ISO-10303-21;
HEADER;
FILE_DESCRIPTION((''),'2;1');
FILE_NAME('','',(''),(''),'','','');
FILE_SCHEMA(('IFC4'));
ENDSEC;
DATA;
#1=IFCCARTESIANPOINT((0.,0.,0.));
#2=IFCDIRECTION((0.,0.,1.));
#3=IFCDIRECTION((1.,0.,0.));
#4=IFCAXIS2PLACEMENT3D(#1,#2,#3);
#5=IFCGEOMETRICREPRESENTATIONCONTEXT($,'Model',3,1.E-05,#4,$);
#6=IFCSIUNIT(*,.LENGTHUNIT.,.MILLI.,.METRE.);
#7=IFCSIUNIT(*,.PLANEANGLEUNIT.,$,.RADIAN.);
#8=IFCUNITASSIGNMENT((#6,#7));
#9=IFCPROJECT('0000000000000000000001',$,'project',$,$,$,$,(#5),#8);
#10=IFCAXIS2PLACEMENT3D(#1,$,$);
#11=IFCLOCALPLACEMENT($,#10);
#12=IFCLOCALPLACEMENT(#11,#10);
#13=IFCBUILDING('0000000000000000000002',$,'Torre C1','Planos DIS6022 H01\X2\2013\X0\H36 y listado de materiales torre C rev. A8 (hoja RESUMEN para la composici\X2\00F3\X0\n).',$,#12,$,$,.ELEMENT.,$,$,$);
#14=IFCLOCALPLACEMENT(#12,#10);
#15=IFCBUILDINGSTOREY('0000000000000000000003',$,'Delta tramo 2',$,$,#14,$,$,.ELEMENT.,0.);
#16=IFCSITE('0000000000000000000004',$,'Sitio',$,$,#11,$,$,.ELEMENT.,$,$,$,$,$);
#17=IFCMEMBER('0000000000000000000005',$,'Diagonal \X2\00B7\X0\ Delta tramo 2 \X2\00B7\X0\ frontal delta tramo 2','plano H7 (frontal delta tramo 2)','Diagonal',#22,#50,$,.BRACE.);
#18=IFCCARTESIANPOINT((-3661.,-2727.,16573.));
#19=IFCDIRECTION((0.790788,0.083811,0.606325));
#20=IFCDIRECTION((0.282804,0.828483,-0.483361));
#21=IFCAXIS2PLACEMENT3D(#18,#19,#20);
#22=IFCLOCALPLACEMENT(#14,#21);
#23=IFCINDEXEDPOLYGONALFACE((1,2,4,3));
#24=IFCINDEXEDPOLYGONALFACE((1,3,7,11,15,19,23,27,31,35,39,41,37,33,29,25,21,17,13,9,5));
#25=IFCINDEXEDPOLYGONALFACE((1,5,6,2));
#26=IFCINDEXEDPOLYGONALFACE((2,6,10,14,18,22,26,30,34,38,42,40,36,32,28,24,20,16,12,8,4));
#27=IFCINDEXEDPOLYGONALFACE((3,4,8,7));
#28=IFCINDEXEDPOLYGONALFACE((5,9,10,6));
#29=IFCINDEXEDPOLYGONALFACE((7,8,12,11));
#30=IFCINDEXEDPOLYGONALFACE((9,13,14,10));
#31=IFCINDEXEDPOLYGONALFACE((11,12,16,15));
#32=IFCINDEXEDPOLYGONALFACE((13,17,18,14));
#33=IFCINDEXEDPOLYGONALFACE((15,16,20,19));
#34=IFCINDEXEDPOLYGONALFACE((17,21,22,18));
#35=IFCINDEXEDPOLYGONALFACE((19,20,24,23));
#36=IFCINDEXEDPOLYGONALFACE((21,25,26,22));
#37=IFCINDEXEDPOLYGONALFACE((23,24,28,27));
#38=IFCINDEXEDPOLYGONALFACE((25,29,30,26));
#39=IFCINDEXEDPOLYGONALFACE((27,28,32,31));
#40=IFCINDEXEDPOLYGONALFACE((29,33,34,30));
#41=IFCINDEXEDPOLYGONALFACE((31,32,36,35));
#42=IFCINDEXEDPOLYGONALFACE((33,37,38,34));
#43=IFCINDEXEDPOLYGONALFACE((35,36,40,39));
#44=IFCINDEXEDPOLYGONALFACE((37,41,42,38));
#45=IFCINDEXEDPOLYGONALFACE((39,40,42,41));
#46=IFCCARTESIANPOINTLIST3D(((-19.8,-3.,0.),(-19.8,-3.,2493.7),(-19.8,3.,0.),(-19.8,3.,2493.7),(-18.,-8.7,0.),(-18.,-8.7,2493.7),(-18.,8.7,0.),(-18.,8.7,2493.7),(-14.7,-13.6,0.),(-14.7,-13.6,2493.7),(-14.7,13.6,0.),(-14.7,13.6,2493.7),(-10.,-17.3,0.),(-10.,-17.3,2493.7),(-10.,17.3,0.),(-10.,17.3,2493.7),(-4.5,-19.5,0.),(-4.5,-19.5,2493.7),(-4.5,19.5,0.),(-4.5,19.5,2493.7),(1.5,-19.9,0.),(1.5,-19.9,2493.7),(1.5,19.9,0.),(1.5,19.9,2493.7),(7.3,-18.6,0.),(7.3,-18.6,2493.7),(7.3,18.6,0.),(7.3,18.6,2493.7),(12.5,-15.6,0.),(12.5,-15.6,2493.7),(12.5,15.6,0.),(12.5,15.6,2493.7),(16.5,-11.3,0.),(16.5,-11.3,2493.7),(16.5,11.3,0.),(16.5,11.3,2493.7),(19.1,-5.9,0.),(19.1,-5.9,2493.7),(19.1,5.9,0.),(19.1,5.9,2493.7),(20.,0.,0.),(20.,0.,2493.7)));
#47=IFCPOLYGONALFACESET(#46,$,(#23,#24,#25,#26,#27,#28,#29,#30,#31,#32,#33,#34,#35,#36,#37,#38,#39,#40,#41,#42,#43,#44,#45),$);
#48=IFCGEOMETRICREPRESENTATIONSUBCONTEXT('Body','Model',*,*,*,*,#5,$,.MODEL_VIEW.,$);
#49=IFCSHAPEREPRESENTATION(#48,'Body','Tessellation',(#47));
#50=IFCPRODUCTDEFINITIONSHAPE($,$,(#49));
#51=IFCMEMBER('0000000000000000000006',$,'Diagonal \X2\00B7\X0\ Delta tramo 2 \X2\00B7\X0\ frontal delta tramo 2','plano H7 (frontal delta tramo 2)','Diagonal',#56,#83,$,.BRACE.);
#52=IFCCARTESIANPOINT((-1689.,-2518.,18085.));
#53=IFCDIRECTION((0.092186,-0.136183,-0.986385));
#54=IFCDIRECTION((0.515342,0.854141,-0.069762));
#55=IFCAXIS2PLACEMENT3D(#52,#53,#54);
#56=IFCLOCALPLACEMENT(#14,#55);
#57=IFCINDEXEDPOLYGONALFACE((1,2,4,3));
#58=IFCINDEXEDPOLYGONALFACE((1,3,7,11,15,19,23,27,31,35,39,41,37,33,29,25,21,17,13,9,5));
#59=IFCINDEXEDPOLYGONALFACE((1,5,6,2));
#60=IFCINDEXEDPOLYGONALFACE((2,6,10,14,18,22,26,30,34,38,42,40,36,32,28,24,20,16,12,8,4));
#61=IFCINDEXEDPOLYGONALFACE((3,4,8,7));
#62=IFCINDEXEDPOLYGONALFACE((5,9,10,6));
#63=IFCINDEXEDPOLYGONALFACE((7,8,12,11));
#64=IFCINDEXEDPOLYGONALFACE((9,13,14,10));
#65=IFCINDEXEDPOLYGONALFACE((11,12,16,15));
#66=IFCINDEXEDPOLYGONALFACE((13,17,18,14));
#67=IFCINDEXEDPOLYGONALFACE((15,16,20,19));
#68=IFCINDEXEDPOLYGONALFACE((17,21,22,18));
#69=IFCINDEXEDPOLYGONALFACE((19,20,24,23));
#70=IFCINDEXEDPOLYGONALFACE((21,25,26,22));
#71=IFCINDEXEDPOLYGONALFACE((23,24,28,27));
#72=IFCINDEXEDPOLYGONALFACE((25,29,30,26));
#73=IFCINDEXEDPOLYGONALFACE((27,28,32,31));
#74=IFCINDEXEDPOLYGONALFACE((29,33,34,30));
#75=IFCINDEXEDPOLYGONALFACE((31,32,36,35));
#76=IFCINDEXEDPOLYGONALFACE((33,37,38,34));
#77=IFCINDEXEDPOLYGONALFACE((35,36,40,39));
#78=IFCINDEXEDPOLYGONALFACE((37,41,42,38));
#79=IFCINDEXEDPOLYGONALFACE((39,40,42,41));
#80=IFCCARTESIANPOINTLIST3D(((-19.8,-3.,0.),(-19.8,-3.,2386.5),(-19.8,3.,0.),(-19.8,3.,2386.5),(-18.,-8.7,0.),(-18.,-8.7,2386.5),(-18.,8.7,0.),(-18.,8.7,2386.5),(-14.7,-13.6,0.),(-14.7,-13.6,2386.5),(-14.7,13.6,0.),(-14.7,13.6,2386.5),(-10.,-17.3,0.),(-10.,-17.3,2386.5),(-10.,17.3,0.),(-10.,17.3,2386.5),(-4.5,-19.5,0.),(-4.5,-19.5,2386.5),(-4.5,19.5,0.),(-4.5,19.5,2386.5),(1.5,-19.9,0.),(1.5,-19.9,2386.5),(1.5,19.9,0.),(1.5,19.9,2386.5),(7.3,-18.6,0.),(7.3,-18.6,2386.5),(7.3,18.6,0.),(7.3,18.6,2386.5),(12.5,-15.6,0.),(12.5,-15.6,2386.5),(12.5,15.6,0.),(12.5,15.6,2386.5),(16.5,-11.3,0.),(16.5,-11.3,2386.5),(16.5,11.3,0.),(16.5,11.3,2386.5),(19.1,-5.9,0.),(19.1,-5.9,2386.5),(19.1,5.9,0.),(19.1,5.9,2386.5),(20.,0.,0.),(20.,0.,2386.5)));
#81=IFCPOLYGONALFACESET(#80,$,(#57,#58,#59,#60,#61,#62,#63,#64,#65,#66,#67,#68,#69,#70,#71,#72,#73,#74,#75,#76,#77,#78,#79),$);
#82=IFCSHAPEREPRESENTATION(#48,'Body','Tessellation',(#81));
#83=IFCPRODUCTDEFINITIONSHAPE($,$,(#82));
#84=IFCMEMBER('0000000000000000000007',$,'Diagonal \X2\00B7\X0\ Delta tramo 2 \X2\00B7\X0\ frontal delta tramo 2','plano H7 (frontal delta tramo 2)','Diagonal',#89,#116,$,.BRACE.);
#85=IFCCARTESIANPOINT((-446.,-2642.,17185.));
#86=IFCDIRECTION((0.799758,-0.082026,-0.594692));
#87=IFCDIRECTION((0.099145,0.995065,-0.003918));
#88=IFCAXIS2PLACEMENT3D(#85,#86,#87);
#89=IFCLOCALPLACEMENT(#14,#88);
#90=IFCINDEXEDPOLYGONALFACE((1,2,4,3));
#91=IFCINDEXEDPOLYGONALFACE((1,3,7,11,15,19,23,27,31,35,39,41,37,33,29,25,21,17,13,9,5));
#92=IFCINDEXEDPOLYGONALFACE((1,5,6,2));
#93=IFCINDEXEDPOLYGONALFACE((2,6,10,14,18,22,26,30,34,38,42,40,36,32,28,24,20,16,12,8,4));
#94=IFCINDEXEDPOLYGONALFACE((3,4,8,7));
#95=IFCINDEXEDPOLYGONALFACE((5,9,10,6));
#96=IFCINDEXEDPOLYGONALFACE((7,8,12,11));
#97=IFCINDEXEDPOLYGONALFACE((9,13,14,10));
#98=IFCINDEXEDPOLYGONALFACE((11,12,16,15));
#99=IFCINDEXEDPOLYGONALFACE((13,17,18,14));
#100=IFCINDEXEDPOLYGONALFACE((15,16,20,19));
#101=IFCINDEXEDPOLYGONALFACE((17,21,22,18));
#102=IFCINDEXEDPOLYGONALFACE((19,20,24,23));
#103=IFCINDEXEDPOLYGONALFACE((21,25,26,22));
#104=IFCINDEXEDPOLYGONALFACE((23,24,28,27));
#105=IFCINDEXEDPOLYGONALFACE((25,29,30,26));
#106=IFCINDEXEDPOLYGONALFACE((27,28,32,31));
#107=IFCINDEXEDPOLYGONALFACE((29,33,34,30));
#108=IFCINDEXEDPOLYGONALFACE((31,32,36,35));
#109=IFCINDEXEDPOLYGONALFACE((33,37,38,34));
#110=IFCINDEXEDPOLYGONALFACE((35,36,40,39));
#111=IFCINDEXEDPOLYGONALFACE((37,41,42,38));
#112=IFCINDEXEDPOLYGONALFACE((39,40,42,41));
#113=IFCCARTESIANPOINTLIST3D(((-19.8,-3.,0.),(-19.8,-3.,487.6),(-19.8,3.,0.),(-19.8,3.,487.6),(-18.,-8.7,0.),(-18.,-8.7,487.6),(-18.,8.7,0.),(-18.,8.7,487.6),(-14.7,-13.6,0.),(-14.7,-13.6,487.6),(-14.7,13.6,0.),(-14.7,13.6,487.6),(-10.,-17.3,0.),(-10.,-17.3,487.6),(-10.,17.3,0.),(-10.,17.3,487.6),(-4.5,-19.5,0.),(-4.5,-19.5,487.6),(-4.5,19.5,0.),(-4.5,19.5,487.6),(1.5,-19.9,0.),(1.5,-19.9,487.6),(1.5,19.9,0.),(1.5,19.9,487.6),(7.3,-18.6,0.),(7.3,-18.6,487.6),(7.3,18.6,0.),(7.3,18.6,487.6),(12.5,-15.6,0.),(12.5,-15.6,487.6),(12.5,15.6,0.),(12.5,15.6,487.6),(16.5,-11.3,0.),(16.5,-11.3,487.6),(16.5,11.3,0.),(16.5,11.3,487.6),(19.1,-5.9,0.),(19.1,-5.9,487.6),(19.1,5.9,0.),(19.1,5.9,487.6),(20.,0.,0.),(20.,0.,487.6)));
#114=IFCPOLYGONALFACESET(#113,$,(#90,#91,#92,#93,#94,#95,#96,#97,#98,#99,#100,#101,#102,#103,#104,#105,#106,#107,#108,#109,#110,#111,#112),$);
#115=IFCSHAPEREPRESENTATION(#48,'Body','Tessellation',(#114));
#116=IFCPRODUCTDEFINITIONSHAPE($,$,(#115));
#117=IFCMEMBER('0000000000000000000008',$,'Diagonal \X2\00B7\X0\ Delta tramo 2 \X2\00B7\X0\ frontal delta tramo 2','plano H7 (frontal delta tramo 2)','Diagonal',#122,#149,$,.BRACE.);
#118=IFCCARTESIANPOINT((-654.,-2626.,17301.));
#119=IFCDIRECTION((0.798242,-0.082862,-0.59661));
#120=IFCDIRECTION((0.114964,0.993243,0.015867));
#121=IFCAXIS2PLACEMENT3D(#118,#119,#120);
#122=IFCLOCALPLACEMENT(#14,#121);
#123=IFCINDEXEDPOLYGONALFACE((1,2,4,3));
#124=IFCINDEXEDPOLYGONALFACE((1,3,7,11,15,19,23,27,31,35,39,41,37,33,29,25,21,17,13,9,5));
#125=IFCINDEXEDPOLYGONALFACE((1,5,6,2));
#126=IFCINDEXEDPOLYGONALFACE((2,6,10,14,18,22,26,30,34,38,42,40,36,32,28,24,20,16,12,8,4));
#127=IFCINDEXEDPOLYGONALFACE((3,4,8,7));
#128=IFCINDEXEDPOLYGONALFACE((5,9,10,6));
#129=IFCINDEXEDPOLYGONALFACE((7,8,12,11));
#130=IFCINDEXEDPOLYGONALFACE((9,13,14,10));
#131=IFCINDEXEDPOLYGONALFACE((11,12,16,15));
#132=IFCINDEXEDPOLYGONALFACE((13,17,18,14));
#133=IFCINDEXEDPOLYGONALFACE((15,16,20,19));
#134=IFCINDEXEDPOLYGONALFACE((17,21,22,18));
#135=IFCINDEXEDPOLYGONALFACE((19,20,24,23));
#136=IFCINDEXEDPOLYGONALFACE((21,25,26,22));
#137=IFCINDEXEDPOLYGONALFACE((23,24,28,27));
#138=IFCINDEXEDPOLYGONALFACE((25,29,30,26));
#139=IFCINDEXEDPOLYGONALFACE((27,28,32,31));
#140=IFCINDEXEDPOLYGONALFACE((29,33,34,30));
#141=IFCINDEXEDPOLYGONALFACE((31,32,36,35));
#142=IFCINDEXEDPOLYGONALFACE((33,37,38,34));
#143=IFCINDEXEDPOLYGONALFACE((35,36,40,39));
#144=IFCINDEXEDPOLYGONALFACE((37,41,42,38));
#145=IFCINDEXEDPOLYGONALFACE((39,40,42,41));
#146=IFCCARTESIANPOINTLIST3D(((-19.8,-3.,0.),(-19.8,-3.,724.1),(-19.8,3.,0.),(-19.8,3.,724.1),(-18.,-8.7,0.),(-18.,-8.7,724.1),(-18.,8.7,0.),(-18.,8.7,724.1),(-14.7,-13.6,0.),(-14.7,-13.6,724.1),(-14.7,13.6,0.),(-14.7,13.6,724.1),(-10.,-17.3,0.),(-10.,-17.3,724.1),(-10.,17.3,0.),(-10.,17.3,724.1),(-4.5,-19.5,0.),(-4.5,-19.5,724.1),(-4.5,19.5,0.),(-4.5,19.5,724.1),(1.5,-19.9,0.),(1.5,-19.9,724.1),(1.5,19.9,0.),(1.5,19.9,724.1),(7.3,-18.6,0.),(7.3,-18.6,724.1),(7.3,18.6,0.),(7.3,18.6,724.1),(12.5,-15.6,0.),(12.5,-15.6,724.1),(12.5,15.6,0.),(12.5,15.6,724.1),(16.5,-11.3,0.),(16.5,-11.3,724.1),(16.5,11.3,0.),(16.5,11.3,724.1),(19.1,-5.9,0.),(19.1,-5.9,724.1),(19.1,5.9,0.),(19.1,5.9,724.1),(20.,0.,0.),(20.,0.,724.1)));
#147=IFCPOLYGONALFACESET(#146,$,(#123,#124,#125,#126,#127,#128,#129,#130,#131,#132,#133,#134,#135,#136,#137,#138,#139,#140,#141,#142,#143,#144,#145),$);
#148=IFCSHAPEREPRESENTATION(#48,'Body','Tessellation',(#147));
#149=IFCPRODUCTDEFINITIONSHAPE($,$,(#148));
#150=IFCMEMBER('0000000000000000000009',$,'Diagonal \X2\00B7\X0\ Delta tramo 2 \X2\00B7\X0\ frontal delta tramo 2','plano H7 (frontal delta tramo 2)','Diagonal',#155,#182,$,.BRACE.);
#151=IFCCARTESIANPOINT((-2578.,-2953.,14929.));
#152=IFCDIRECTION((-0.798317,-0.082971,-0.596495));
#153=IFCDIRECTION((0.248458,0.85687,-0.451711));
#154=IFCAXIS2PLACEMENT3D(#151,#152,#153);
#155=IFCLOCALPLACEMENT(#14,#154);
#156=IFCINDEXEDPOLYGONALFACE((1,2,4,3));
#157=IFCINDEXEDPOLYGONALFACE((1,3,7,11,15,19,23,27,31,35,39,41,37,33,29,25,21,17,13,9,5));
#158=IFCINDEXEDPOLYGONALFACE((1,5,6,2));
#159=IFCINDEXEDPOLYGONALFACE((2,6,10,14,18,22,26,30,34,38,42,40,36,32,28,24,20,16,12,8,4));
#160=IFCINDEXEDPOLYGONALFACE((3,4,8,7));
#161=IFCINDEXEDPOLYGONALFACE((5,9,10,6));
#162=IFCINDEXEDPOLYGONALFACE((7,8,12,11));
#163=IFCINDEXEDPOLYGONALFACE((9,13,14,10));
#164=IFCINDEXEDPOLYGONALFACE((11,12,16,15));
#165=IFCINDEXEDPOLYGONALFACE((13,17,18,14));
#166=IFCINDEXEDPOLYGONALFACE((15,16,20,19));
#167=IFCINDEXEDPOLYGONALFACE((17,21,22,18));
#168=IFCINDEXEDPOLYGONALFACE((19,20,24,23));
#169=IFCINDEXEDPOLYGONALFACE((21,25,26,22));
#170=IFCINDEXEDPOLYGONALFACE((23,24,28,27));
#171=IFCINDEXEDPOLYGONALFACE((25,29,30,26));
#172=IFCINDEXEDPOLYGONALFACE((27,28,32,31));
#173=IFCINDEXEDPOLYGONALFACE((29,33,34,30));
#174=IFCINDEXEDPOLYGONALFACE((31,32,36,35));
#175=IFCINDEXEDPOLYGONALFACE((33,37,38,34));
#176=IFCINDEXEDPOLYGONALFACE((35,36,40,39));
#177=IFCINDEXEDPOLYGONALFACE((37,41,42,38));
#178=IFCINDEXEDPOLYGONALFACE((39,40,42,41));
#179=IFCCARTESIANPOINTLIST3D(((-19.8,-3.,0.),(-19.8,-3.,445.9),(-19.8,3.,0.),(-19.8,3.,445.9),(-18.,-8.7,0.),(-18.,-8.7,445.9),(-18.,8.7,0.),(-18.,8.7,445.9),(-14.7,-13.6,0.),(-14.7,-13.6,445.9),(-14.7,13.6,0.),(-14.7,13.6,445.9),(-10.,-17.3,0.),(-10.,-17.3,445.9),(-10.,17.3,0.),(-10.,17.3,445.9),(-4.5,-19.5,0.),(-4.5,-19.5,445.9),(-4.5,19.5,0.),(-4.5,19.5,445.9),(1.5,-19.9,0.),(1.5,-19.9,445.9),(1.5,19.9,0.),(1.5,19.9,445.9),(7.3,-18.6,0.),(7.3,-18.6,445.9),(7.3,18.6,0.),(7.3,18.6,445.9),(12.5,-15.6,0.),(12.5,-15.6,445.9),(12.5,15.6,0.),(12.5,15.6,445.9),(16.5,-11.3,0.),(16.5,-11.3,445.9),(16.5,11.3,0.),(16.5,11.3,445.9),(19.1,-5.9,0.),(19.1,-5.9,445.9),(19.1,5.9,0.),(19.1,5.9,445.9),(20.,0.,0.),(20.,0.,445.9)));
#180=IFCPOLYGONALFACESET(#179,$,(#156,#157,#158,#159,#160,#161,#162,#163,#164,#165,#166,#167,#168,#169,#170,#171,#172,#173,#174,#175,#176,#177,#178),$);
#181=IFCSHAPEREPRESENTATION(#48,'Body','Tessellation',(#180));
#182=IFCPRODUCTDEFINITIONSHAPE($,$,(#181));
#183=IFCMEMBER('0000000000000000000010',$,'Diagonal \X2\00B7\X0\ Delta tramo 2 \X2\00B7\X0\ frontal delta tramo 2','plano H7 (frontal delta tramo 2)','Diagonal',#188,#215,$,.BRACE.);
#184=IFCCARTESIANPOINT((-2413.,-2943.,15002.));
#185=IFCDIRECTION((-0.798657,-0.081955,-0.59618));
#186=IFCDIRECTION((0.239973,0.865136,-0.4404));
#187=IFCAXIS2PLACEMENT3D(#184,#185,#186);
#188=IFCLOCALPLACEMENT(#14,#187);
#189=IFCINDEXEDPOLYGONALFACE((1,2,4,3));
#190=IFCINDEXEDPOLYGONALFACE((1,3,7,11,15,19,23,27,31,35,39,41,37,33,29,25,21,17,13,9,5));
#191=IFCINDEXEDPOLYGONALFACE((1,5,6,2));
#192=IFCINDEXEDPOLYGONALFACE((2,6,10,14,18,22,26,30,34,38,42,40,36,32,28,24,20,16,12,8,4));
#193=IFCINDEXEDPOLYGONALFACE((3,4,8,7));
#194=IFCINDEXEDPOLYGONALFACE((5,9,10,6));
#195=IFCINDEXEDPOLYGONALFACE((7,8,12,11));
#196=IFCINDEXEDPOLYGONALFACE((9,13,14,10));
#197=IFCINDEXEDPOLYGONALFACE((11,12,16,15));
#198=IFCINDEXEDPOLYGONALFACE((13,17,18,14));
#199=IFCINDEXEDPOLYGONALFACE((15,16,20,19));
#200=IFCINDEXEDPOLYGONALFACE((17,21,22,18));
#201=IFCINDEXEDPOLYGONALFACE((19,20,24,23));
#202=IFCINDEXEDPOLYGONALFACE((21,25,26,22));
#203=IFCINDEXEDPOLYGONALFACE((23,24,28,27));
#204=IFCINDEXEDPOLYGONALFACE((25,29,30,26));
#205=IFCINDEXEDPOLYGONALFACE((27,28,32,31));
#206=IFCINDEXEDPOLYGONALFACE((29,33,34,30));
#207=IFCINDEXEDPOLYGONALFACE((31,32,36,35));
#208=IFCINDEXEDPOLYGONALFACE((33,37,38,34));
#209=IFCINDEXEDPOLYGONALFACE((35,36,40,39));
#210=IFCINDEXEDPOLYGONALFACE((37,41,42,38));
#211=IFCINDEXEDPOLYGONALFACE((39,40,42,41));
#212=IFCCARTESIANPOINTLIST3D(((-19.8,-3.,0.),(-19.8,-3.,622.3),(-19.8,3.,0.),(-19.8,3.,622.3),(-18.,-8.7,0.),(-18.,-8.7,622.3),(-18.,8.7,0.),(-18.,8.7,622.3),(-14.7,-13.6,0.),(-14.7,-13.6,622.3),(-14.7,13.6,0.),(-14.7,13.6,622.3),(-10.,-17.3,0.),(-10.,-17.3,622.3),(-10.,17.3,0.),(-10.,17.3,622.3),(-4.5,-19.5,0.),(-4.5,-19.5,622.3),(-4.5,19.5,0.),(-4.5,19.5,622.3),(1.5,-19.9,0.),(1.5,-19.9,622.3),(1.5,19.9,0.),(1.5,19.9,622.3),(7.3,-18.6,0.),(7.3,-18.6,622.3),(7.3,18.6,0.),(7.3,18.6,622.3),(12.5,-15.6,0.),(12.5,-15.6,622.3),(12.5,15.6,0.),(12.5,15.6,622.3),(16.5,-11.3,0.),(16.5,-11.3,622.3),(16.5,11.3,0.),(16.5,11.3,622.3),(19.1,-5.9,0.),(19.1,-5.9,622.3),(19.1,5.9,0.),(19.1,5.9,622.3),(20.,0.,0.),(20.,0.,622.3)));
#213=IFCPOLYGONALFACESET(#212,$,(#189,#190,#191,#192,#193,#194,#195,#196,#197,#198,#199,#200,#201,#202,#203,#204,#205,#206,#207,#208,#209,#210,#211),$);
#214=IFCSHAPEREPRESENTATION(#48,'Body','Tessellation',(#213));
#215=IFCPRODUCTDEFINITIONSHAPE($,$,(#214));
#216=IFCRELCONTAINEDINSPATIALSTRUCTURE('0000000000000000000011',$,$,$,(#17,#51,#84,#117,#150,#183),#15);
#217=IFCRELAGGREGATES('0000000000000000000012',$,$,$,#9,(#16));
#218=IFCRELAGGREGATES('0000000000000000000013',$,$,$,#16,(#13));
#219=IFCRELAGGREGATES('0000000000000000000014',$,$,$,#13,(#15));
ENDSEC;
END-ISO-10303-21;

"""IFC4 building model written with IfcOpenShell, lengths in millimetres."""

from ifc_helpers import new_model, si_unit, frame, origin, origin_with_axes, place, context, subcontext, project, spatial, circle, extrude, element, save


model = new_model("IFC4")

# Units and contexts
model_context = context("Model", 3, precision=1e-05, world=origin_with_axes())
body_context = subcontext(model_context, "Body", "Model", "MODEL_VIEW")
ifc_project = project(units=[si_unit("LENGTHUNIT", "METRE", prefix="MILLI"), si_unit("PLANEANGLEUNIT", "RADIAN")], contexts=[model_context])

# Site, building, storey
site_placement = place(None, origin())
site = spatial("IfcSite", under=ifc_project, at=site_placement, Name="Sitio", CompositionType="ELEMENT")
building_placement = place(site_placement, origin())
building = spatial("IfcBuilding", under=site, at=building_placement, Name="Torre C1", Description="Planos DIS6022 H01–H36 y listado de materiales torre C rev. A8 (hoja RESUMEN para la composición).", CompositionType="ELEMENT")
storey_placement = place(building_placement, origin())
storey = spatial("IfcBuildingStorey", under=building, at=storey_placement, Name="Delta tramo 2", CompositionType="ELEMENT", Elevation=0.0)

# Members
member_1_placement = place(storey_placement, frame((-3661.0, -2727.0, 16573.0), z_axis=(0.790788, 0.083811, 0.606325), x_axis=(0.282804, 0.828483, -0.483361)))
element("IfcMember", 1, at=member_1_placement, inside=storey, Name="Diagonal · Delta tramo 2 · frontal delta tramo 2", Description="plano H7 (frontal delta tramo 2)", ObjectType="Diagonal", PredefinedType="BRACE", context=body_context, shape_type="SweptSolid", body=[
    extrude(circle(Radius=20.0), None, (0.0, 0.0, 1.0), 2493.7),
])
member_2_placement = place(storey_placement, frame((-1689.0, -2518.0, 18085.0), z_axis=(0.092186, -0.136183, -0.986385), x_axis=(0.515342, 0.854141, -0.069762)))
element("IfcMember", 2, at=member_2_placement, inside=storey, Name="Diagonal · Delta tramo 2 · frontal delta tramo 2", Description="plano H7 (frontal delta tramo 2)", ObjectType="Diagonal", PredefinedType="BRACE", context=body_context, shape_type="SweptSolid", body=[
    extrude(circle(Radius=20.0), None, (0.0, 0.0, 1.0), 2386.5),
])
member_3_placement = place(storey_placement, frame((-446.0, -2642.0, 17185.0), z_axis=(0.799758, -0.082026, -0.594692), x_axis=(0.099145, 0.995065, -0.003918)))
element("IfcMember", 3, at=member_3_placement, inside=storey, Name="Diagonal · Delta tramo 2 · frontal delta tramo 2", Description="plano H7 (frontal delta tramo 2)", ObjectType="Diagonal", PredefinedType="BRACE", context=body_context, shape_type="SweptSolid", body=[
    extrude(circle(Radius=20.0), None, (0.0, 0.0, 1.0), 487.6),
])
member_4_placement = place(storey_placement, frame((-654.0, -2626.0, 17301.0), z_axis=(0.798242, -0.082862, -0.59661), x_axis=(0.114964, 0.993243, 0.015867)))
element("IfcMember", 4, at=member_4_placement, inside=storey, Name="Diagonal · Delta tramo 2 · frontal delta tramo 2", Description="plano H7 (frontal delta tramo 2)", ObjectType="Diagonal", PredefinedType="BRACE", context=body_context, shape_type="SweptSolid", body=[
    extrude(circle(Radius=20.0), None, (0.0, 0.0, 1.0), 724.1),
])
member_5_placement = place(storey_placement, frame((-2578.0, -2953.0, 14929.0), z_axis=(-0.798317, -0.082971, -0.596495), x_axis=(0.248458, 0.85687, -0.451711)))
element("IfcMember", 5, at=member_5_placement, inside=storey, Name="Diagonal · Delta tramo 2 · frontal delta tramo 2", Description="plano H7 (frontal delta tramo 2)", ObjectType="Diagonal", PredefinedType="BRACE", context=body_context, shape_type="SweptSolid", body=[
    extrude(circle(Radius=20.0), None, (0.0, 0.0, 1.0), 445.9),
])
member_6_placement = place(storey_placement, frame((-2413.0, -2943.0, 15002.0), z_axis=(-0.798657, -0.081955, -0.59618), x_axis=(0.239973, 0.865136, -0.4404)))
element("IfcMember", 6, at=member_6_placement, inside=storey, Name="Diagonal · Delta tramo 2 · frontal delta tramo 2", Description="plano H7 (frontal delta tramo 2)", ObjectType="Diagonal", PredefinedType="BRACE", context=body_context, shape_type="SweptSolid", body=[
    extrude(circle(Radius=20.0), None, (0.0, 0.0, 1.0), 622.3),
])

save(model, "model.ifc")
